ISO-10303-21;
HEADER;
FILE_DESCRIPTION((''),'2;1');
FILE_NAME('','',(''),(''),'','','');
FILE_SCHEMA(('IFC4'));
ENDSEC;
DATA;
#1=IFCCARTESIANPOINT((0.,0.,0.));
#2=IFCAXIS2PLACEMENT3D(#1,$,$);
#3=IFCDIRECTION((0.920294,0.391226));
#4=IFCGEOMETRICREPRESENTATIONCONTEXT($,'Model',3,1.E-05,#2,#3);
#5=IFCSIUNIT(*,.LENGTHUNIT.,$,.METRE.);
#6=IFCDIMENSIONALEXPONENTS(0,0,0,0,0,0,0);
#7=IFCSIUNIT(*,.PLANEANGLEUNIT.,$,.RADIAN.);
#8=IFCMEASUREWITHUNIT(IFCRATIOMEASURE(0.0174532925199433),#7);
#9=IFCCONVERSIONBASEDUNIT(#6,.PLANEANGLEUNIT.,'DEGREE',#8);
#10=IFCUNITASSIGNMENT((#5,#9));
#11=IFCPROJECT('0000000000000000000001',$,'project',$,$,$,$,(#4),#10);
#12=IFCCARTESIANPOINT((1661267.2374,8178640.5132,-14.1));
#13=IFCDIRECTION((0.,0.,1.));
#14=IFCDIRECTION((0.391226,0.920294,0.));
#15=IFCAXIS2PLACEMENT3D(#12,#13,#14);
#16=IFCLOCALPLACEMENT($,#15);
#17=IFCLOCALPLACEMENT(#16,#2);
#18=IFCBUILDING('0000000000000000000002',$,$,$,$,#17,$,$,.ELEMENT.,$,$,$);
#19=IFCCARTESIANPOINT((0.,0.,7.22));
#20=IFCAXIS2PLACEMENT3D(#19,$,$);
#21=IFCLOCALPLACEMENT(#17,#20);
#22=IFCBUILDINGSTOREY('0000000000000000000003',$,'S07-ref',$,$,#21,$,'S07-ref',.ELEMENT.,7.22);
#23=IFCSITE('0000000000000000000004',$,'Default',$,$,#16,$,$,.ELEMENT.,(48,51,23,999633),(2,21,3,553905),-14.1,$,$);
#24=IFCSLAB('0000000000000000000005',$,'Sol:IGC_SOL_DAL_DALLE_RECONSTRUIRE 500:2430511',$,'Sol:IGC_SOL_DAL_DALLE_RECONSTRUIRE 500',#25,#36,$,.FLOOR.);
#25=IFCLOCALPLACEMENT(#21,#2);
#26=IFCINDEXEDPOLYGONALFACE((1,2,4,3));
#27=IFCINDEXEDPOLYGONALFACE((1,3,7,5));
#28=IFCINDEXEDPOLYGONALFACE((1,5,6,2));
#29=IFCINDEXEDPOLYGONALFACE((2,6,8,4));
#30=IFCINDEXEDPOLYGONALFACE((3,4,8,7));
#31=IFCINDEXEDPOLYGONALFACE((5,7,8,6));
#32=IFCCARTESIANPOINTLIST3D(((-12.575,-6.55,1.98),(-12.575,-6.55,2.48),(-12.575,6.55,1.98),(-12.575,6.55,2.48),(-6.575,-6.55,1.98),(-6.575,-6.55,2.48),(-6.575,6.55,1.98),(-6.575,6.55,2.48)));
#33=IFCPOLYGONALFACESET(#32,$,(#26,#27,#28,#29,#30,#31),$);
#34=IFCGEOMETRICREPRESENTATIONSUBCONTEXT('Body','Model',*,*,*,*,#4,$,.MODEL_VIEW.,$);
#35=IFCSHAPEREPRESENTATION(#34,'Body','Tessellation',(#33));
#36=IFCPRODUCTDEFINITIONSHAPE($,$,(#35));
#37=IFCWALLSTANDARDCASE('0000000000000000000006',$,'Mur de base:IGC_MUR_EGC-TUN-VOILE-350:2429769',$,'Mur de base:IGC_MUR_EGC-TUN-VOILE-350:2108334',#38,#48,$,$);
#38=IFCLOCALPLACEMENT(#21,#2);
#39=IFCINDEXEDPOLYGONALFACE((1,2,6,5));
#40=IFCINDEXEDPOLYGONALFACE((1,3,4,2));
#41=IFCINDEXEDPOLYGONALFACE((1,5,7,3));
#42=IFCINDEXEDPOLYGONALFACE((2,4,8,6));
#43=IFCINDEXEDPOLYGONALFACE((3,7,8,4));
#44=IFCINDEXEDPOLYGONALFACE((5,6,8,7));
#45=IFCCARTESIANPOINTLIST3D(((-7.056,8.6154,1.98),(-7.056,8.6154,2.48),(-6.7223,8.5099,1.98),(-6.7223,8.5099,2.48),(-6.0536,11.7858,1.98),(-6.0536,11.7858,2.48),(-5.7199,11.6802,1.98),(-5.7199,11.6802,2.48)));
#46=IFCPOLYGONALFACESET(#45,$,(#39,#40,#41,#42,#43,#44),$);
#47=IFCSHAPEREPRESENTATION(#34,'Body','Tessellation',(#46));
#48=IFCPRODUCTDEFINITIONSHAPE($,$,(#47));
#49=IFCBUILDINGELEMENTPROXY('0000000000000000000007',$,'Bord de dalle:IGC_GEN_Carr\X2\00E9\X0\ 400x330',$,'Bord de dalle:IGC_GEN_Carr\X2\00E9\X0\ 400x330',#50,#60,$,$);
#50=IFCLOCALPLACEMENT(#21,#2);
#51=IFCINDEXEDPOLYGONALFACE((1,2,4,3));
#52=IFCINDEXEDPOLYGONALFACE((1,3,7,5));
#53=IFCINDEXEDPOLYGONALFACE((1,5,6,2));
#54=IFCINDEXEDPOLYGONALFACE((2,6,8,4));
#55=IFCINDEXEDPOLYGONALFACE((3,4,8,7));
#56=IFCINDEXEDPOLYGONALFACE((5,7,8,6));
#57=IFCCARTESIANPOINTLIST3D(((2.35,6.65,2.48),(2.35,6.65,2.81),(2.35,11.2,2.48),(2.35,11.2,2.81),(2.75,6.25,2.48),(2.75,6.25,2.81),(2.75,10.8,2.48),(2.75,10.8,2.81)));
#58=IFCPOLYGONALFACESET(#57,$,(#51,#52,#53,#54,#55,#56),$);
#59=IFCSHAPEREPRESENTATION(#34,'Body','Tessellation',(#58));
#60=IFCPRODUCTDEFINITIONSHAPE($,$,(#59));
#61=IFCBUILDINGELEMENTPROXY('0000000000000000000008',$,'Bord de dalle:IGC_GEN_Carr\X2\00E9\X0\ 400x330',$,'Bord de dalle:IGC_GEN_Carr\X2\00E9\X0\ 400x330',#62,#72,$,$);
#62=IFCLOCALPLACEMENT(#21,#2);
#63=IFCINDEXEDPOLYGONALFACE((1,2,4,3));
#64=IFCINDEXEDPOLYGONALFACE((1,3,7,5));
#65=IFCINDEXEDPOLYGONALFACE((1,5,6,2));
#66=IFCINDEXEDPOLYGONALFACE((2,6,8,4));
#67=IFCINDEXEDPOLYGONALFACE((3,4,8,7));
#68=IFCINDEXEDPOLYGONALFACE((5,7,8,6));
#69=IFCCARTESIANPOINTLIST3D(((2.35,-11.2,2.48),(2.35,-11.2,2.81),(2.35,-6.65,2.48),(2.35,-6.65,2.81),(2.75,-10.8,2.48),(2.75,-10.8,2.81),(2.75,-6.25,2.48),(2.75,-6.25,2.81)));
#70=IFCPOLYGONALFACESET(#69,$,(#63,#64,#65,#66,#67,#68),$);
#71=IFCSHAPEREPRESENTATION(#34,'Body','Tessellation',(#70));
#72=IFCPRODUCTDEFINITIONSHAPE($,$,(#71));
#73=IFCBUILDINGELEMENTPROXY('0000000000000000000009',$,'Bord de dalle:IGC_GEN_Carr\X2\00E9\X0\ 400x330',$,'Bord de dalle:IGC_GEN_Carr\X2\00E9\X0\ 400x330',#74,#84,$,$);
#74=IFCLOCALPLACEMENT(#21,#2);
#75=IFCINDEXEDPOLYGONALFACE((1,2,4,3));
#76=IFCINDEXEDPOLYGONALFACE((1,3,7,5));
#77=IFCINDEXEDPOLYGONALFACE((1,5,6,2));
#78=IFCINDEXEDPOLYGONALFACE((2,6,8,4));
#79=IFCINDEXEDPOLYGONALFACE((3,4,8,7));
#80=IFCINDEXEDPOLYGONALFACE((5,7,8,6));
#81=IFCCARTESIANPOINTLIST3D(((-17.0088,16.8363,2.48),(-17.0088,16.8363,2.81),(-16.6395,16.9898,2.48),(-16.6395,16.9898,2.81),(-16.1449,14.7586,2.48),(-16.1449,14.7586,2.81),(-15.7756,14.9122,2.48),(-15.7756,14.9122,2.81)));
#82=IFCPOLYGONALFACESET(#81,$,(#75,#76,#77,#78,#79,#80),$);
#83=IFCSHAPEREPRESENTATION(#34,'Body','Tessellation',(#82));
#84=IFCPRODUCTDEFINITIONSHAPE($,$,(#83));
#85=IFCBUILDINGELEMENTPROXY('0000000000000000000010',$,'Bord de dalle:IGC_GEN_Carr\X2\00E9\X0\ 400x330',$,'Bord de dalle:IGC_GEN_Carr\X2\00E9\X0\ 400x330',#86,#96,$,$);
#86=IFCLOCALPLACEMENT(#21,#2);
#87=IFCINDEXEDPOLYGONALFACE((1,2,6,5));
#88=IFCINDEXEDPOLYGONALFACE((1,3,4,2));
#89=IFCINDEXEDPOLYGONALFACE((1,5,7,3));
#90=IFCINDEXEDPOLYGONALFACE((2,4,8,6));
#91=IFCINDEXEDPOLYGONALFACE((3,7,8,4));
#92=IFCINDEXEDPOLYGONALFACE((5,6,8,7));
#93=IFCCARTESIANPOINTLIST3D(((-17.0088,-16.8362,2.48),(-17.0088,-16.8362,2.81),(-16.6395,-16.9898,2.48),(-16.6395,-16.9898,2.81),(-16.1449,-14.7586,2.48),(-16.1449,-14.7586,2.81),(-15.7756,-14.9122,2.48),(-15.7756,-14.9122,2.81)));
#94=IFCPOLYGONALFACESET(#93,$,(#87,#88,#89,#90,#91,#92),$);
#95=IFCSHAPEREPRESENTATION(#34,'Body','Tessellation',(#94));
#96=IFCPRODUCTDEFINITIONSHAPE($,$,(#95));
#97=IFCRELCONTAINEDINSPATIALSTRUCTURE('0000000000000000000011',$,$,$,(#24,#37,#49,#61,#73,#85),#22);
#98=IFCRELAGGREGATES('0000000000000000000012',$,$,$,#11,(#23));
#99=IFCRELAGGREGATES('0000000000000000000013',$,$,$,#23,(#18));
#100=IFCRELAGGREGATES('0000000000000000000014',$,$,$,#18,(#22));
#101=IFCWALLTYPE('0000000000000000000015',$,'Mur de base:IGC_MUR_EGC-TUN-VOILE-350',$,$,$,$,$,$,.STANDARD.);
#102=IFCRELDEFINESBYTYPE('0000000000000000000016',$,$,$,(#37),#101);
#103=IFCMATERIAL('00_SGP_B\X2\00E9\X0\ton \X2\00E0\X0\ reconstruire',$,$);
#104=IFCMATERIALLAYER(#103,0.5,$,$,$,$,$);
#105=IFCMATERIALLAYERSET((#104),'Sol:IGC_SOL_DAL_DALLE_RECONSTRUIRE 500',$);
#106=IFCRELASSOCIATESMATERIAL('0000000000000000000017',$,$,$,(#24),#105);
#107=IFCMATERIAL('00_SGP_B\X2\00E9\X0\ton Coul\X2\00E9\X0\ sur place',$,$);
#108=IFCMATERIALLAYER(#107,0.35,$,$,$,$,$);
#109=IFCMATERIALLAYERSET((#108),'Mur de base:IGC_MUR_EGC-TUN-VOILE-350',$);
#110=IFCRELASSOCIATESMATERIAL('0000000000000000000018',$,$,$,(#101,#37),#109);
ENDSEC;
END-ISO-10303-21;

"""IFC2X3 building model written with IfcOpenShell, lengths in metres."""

from ifc_helpers import new_model, entity, si_unit, converted_unit, direction, frame, frame_2d, origin, origin_2d_with_axis, place, context, subcontext, project, spatial, polyline, rectangle, outline, extrude, material, layer, layer_set, layer_usage, type_object, element, save


model = new_model("IFC2X3")

# Units and contexts
model_context = context("Model", 3, precision=1e-05, world=origin(), true_north=direction((0.920294, 0.391226)))
body_context = subcontext(model_context, "Body", "Model", "MODEL_VIEW")
ifc_project = project(units=[si_unit("LENGTHUNIT", "METRE"), converted_unit("PLANEANGLEUNIT", "DEGREE", entity("IfcRatioMeasure", 0.0174532925199433), si_unit("PLANEANGLEUNIT", "RADIAN"), dimensions=[0, 0, 0, 0, 0, 0, 0])], contexts=[model_context])

# Site, building, storey
site_placement = place(None, frame((1661267.2374, 8178640.5132, -14.1), z_axis=(0.0, 0.0, 1.0), x_axis=(0.391226, 0.920294, 0.0)))
site = spatial("IfcSite", under=ifc_project, at=site_placement, Name="Default", CompositionType="ELEMENT", RefLatitude=(48, 51, 23, 999633), RefLongitude=(2, 21, 3, 553905), RefElevation=-14.1)
building_placement = place(site_placement, origin())
building = spatial("IfcBuilding", under=site, at=building_placement, CompositionType="ELEMENT")
storey_placement = place(building_placement, frame((0.0, 0.0, 7.22)))
storey = spatial("IfcBuildingStorey", under=building, at=storey_placement, Name="S07-ref", LongName="S07-ref", CompositionType="ELEMENT", Elevation=7.22)

# Slab
ifc_material_1 = material(Name="00_SGP_Béton à reconstruire")
ifc_layer_1 = layer(ifc_material_1, 0.5)
ifc_layer_set_1 = layer_set([ifc_layer_1], Name="Sol:IGC_SOL_DAL_DALLE_RECONSTRUIRE 500")
ifc_layer_usage_1 = layer_usage(ifc_layer_set_1, "AXIS3", "POSITIVE", 0.0)
slab_1_placement = place(storey_placement, origin())
element("IfcSlab", 1, at=slab_1_placement, inside=storey, material=ifc_layer_usage_1, Name="Sol:IGC_SOL_DAL_DALLE_RECONSTRUIRE 500:2430511", ObjectType="Sol:IGC_SOL_DAL_DALLE_RECONSTRUIRE 500", PredefinedType="FLOOR", context=body_context, shape_type="SweptSolid", body=[
    extrude(outline(polyline([(-6.55, -3.0), (6.55, -3.0), (6.55, 3.0), (-6.55, 3.0), (-6.55, -3.0)])), frame((-9.575, 0.0, 2.48), z_axis=(0.0, 0.0, -1.0), x_axis=(0.0, 1.0, 0.0)), (0.0, 0.0, 1.0), 0.5),
])
ifc_material_2 = material(Name="00_SGP_Béton Coulé sur place")

# Wall
ifc_layer_2 = layer(ifc_material_2, 0.35)
ifc_layer_set_2 = layer_set([ifc_layer_2], Name="Mur de base:IGC_MUR_EGC-TUN-VOILE-350")
ifc_layer_usage_2 = layer_usage(ifc_layer_set_2, "AXIS2", "POSITIVE", -0.175)
wall_type_1 = type_object("IfcWallType", Name="Mur de base:IGC_MUR_EGC-TUN-VOILE-350", PredefinedType="STANDARD", material=ifc_layer_set_2)
wall_1_placement = place(storey_placement, frame((-6.8892, 8.5627, 1.98), z_axis=(0.0, 0.0, 1.0), x_axis=(0.301469, 0.953476, 0.0)))
element("IfcWallStandardCase", 2, at=wall_1_placement, inside=storey, type_object=wall_type_1, material=ifc_layer_usage_2, Name="Mur de base:IGC_MUR_EGC-TUN-VOILE-350:2429769", ObjectType="Mur de base:IGC_MUR_EGC-TUN-VOILE-350:2108334", context=body_context, shape_type="SweptSolid", body=[
    extrude(rectangle(XDim=3.325, YDim=0.35, at=frame_2d((1.6625, 0.0), x_axis=(-1.0, 0.0))), origin(), (0.0, 0.0, 1.0), 0.5),
])

# Building element proxies
proxy_1_placement = place(storey_placement, origin())
element("IfcBuildingElementProxy", 3, at=proxy_1_placement, inside=storey, Name="Bord de dalle:IGC_GEN_Carré 400x330", ObjectType="Bord de dalle:IGC_GEN_Carré 400x330", context=body_context, shape_type="SweptSolid", body=[
    extrude(outline(polyline([(-2.475, -0.2), (2.075, -0.2), (2.475, 0.2), (-2.075, 0.2), (-2.475, -0.2)])), frame((2.55, 8.725, 2.48), z_axis=(0.0, 0.0, 1.0), x_axis=(0.0, 1.0, 0.0)), (0.0, 0.0, 1.0), 0.33),
])
proxy_2_placement = place(storey_placement, origin())
element("IfcBuildingElementProxy", 4, at=proxy_2_placement, inside=storey, Name="Bord de dalle:IGC_GEN_Carré 400x330", ObjectType="Bord de dalle:IGC_GEN_Carré 400x330", context=body_context, shape_type="SweptSolid", body=[
    extrude(outline(polyline([(-2.075, -0.2), (2.475, -0.2), (2.075, 0.2), (-2.475, 0.2), (-2.075, -0.2)])), frame((2.55, -8.725, 2.48), z_axis=(0.0, 0.0, 1.0), x_axis=(0.0, 1.0, 0.0)), (0.0, 0.0, 1.0), 0.33),
])
proxy_3_placement = place(storey_placement, origin())
element("IfcBuildingElementProxy", 5, at=proxy_3_placement, inside=storey, Name="Bord de dalle:IGC_GEN_Carré 400x330", ObjectType="Bord de dalle:IGC_GEN_Carré 400x330", context=body_context, shape_type="SweptSolid", body=[
    extrude(rectangle(XDim=2.2501, YDim=0.4, at=origin_2d_with_axis()), frame((-16.3922, 15.8742, 2.48), z_axis=(0.0, 0.0, 1.0), x_axis=(-0.383938, 0.923359, 0.0)), (0.0, 0.0, 1.0), 0.33),
])
proxy_4_placement = place(storey_placement, origin())
element("IfcBuildingElementProxy", 6, at=proxy_4_placement, inside=storey, Name="Bord de dalle:IGC_GEN_Carré 400x330", ObjectType="Bord de dalle:IGC_GEN_Carré 400x330", context=body_context, shape_type="SweptSolid", body=[
    extrude(rectangle(XDim=2.25, YDim=0.4, at=origin_2d_with_axis()), frame((-16.3922, -15.8742, 2.48), z_axis=(0.0, 0.0, 1.0), x_axis=(0.383938, 0.923359, 0.0)), (0.0, 0.0, 1.0), 0.33),
])

save(model, "model.ifc")
